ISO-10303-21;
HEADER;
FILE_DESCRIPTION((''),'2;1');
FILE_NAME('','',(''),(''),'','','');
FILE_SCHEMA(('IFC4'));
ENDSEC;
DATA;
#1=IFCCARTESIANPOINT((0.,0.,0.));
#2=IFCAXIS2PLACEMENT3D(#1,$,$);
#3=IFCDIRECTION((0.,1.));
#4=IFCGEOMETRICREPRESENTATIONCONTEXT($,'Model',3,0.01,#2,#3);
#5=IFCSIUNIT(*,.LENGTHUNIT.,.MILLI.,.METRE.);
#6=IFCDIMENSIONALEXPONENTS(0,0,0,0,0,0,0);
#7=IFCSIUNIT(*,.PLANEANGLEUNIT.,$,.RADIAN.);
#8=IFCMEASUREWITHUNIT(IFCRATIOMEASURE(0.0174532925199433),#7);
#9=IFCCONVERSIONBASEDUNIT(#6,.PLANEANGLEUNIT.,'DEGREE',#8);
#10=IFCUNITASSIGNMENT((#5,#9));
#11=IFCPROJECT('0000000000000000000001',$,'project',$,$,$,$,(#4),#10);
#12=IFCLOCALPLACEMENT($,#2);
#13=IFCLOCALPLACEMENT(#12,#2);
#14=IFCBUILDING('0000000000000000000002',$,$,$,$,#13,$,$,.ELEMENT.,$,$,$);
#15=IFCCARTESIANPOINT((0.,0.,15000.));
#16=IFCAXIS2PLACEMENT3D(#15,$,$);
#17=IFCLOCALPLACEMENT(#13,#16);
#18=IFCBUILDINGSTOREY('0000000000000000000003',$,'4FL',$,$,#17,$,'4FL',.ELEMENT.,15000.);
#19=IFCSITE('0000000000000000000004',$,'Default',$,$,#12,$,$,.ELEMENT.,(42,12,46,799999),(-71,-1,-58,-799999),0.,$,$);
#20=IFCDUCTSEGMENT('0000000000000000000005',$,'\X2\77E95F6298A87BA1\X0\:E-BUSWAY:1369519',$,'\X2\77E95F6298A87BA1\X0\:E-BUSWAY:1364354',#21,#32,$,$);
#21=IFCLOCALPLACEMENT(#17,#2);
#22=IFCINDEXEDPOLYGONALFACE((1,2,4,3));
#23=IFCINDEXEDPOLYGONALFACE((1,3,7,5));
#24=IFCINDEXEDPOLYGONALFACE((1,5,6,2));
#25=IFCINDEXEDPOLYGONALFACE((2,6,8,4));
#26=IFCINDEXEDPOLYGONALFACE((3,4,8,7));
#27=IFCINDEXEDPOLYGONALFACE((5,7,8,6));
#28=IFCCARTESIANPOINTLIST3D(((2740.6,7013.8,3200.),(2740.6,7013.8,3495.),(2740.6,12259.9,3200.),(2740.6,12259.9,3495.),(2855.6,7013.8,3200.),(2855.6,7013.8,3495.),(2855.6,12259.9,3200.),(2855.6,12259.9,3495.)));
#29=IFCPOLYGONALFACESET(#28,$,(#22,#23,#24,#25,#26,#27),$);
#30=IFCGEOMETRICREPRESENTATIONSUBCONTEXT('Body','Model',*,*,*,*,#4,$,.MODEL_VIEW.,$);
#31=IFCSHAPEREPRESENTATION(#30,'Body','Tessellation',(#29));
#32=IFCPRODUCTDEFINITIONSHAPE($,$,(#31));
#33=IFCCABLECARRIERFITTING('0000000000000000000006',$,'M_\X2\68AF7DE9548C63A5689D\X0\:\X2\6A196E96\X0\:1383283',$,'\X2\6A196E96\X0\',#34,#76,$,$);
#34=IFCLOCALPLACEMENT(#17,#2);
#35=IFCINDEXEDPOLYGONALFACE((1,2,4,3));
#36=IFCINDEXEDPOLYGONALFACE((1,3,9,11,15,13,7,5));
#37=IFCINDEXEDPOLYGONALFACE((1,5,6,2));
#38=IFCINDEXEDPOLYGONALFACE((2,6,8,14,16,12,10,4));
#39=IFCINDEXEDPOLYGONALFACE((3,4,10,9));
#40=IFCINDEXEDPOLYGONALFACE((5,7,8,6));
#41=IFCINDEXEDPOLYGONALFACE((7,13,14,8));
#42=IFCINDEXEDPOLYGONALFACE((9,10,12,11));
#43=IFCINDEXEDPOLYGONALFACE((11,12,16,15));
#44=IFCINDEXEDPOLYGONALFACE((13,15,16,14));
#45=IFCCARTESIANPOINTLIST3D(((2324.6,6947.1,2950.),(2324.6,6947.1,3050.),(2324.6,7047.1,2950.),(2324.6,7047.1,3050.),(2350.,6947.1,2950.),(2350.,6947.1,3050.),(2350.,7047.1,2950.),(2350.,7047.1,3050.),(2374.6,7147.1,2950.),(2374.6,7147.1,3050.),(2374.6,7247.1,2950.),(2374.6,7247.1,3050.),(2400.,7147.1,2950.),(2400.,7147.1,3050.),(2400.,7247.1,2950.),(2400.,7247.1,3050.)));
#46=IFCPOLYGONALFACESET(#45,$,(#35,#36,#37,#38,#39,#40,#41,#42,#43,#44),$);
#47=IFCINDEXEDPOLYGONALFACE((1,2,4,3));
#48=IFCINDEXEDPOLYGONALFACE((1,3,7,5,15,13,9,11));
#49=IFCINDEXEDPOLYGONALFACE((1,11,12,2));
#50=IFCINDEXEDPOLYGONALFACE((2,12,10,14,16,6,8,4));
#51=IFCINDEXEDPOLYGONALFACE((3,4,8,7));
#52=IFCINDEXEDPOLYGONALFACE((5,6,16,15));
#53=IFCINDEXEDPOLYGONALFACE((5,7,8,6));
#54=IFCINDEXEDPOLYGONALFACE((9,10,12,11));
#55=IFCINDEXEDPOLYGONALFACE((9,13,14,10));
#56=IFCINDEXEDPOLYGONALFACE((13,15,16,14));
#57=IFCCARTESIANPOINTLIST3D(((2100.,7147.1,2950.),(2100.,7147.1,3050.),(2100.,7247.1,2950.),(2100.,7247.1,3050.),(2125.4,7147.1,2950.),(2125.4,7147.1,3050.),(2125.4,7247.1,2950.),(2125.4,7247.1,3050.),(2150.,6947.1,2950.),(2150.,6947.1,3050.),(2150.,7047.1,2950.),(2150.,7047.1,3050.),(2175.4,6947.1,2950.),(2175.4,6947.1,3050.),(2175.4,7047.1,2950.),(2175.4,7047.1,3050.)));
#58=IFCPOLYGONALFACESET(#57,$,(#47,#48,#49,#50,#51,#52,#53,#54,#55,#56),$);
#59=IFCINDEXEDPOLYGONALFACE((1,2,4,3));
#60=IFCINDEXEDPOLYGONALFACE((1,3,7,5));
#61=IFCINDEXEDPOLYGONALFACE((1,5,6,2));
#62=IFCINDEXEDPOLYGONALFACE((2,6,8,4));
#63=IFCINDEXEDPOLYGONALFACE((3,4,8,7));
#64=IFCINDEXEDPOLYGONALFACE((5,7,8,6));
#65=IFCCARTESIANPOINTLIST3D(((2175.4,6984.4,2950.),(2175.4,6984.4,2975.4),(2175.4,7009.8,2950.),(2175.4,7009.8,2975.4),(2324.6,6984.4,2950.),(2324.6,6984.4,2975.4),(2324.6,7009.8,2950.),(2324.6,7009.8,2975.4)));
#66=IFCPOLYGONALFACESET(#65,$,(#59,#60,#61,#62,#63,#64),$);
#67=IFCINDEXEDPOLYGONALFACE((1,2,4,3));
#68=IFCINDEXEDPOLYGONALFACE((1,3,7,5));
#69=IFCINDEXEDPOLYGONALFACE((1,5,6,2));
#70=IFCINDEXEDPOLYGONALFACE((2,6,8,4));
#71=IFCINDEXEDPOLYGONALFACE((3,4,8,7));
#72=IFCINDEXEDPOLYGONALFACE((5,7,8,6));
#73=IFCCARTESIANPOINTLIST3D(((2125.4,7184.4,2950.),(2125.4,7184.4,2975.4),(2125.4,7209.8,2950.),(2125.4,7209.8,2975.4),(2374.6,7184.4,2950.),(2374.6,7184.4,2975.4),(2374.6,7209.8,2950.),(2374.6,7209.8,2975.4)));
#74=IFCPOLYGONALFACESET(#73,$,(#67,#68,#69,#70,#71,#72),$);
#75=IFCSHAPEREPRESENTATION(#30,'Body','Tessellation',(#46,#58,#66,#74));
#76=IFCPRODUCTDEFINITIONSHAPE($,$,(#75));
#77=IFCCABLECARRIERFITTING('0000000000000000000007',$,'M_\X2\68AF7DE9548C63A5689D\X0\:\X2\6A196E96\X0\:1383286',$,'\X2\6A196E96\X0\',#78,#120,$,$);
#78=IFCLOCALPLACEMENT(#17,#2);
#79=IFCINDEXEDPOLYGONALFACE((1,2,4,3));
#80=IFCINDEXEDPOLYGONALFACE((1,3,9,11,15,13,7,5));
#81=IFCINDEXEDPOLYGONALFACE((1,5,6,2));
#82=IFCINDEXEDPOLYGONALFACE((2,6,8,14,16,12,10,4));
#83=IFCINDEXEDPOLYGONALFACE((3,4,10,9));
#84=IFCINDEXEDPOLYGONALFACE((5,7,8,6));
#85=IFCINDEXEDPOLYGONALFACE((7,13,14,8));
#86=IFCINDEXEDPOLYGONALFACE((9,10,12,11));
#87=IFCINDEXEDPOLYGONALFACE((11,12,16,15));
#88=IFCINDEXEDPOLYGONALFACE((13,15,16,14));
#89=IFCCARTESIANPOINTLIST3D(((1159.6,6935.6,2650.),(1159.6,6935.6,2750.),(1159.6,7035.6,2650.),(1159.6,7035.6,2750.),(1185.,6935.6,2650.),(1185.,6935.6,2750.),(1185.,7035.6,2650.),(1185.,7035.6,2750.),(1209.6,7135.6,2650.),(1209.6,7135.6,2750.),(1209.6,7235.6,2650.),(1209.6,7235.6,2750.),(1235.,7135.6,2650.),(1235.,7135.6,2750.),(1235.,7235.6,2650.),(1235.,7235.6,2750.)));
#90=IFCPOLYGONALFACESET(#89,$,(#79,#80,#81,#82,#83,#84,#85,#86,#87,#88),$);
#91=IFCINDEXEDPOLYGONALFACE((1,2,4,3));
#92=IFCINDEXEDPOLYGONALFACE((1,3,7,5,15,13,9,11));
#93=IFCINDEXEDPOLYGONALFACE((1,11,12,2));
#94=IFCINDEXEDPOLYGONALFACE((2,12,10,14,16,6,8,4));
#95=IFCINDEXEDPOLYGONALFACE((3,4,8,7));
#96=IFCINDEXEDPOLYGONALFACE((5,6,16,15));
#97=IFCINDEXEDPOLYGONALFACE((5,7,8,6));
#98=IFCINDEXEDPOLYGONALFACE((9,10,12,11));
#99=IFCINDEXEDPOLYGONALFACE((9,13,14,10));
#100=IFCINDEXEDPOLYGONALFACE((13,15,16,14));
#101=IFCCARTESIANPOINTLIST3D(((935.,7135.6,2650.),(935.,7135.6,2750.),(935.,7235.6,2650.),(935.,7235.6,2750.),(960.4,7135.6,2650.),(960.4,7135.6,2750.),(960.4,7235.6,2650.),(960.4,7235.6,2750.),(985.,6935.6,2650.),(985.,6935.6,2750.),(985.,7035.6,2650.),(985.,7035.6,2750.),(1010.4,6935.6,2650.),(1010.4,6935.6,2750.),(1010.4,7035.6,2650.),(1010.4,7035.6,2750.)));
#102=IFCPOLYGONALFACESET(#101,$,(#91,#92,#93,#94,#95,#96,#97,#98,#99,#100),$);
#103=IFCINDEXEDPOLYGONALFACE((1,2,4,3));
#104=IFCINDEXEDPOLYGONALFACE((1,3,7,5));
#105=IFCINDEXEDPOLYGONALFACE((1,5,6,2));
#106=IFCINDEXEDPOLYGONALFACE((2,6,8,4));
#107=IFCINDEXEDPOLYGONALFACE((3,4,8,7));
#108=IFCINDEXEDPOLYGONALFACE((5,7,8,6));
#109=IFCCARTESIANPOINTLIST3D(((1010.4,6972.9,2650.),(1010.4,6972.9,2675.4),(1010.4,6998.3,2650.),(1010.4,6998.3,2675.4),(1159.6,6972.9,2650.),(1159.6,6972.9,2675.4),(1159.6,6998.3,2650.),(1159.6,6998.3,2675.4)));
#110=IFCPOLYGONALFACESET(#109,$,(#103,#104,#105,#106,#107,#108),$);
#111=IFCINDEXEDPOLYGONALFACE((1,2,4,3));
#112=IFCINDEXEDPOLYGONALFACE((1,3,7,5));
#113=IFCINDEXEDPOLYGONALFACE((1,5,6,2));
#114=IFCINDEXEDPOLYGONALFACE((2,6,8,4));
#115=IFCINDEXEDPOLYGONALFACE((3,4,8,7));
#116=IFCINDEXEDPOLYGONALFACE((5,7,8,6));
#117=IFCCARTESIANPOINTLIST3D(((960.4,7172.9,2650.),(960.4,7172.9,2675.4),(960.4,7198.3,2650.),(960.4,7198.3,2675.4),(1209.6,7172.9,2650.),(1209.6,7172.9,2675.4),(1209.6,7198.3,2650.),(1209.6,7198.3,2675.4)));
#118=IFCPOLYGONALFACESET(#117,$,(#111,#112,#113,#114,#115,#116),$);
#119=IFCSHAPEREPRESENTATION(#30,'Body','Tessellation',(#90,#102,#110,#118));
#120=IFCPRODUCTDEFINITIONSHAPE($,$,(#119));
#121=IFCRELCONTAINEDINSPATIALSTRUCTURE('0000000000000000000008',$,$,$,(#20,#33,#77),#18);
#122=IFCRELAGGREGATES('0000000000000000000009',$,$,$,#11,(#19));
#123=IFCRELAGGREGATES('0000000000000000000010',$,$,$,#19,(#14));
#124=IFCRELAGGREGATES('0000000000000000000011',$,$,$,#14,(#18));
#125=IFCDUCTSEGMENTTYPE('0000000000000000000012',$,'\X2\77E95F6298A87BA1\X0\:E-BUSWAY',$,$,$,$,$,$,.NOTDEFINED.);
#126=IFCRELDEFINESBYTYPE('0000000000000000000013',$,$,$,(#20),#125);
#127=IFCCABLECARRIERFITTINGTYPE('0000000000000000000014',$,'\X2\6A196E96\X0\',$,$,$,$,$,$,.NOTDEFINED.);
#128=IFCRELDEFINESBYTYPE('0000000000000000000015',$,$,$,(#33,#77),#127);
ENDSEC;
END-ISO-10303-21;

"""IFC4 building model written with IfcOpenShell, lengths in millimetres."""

from ifc_helpers import new_model, entity, si_unit, converted_unit, direction, frame, frame_2d, origin, origin_2d_with_axis, place, context, subcontext, project, spatial, polyline, rectangle, outline, extrude, source, transform, mapped, type_object, type_shapes, element, save


model = new_model("IFC4")

# Units and contexts
model_context = context("Model", 3, precision=0.01, world=origin(), true_north=direction((0.0, 1.0)))
body_context = subcontext(model_context, "Body", "Model", "MODEL_VIEW")
ifc_project = project(units=[si_unit("LENGTHUNIT", "METRE", prefix="MILLI"), converted_unit("PLANEANGLEUNIT", "DEGREE", entity("IfcRatioMeasure", 0.0174532925199433), si_unit("PLANEANGLEUNIT", "RADIAN"), dimensions=[0, 0, 0, 0, 0, 0, 0])], contexts=[model_context])

# Site, building, storey
site_placement = place(None, origin())
site = spatial("IfcSite", under=ifc_project, at=site_placement, Name="Default", CompositionType="ELEMENT", RefLatitude=(42, 12, 46, 799999), RefLongitude=(-71, -1, -58, -799999), RefElevation=0.0)
building_placement = place(site_placement, origin())
building = spatial("IfcBuilding", under=site, at=building_placement, CompositionType="ELEMENT")
storey_placement = place(building_placement, frame((0.0, 0.0, 15000.0)))
storey = spatial("IfcBuildingStorey", under=building, at=storey_placement, Name="4FL", LongName="4FL", CompositionType="ELEMENT", Elevation=15000.0)

# Duct segment
duct_segment_type = type_object("IfcDuctSegmentType", Name="矩形風管:E-BUSWAY", PredefinedType="NOTDEFINED")
duct_segment_1_placement = place(storey_placement, frame((2740.6, 7013.8, 3200.0)))
element("IfcDuctSegment", 1, at=duct_segment_1_placement, inside=storey, type_object=duct_segment_type, Name="矩形風管:E-BUSWAY:1369519", ObjectType="矩形風管:E-BUSWAY:1364354", context=body_context, shape_type="SweptSolid", body=[
    extrude(rectangle(XDim=5246.1, YDim=115.0, at=frame_2d((0.0, 0.0), x_axis=(1.0, 0.0))), frame((57.5, 2623.1, 0.0), z_axis=(0.0, 0.0, 1.0), x_axis=(0.0, -1.0, 0.0)), (0.0, 0.0, 1.0), 295.0),
])

# Cable carrier fittings
cable_carrier_fitting_type_1 = type_object("IfcCableCarrierFittingType", Name="標準", PredefinedType="NOTDEFINED")
shared_shape_1 = source(origin(), body_context, "Body", "SweptSolid", [
    extrude(outline(polyline([(-150.0, -12.3), (-150.0, -37.7), (-50.0, -37.7), (50.0, 12.3), (150.0, 12.3), (150.0, 37.7), (50.0, 37.7), (-50.0, -12.3), (-150.0, -12.3)])), frame((150.0, 112.3, -50.0), z_axis=(0.0, 0.0, -1.0), x_axis=(1.0, 0.0, 0.0)), (0.0, 0.0, -1.0), 100.0),
    extrude(outline(polyline([(-150.0, -37.7), (-50.0, -37.7), (50.0, 12.3), (150.0, 12.3), (150.0, 37.7), (50.0, 37.7), (-50.0, -12.3), (-150.0, -12.3), (-150.0, -37.7)])), frame((150.0, -112.3, -50.0)), (0.0, 0.0, 1.0), 100.0),
    extrude(rectangle(XDim=149.2, YDim=25.4, at=frame_2d((0.0, 0.0), x_axis=(1.0, 0.0))), frame((250.0, 0.0, -50.0), z_axis=(0.0, 0.0, 1.0), x_axis=(0.0, -1.0, 0.0)), (0.0, 0.0, 1.0), 25.4),
    extrude(rectangle(XDim=249.2, YDim=25.4, at=origin_2d_with_axis()), frame((50.0, 0.0, -50.0), z_axis=(0.0, 0.0, 1.0), x_axis=(0.0, -1.0, 0.0)), (0.0, 0.0, 1.0), 25.4),
])
type_shapes(cable_carrier_fitting_type_1, [shared_shape_1])
for number, where, z_axis, x_axis, name in (
    (2, (2250.0, 7247.1, 3000.0), (0.0, 0.0, 1.0), (0.0, -1.0, 0.0), "M_梯緩和接條:標準:1383283"),
    (3, (1085.0, 7235.6, 2700.0), (0.0, 0.0, 1.0), (0.0, -1.0, 0.0), "M_梯緩和接條:標準:1383286"),
):
    element("IfcCableCarrierFitting", number, at=place(storey_placement, frame(where, z_axis=z_axis, x_axis=x_axis)), inside=storey, type_object=cable_carrier_fitting_type_1, Name=name, ObjectType="標準", context=body_context, shape_type="MappedRepresentation", body=[
        mapped(shared_shape_1, transform((0.0, 0.0, 0.0), scale=1.0)),
    ])

save(model, "model.ifc")
